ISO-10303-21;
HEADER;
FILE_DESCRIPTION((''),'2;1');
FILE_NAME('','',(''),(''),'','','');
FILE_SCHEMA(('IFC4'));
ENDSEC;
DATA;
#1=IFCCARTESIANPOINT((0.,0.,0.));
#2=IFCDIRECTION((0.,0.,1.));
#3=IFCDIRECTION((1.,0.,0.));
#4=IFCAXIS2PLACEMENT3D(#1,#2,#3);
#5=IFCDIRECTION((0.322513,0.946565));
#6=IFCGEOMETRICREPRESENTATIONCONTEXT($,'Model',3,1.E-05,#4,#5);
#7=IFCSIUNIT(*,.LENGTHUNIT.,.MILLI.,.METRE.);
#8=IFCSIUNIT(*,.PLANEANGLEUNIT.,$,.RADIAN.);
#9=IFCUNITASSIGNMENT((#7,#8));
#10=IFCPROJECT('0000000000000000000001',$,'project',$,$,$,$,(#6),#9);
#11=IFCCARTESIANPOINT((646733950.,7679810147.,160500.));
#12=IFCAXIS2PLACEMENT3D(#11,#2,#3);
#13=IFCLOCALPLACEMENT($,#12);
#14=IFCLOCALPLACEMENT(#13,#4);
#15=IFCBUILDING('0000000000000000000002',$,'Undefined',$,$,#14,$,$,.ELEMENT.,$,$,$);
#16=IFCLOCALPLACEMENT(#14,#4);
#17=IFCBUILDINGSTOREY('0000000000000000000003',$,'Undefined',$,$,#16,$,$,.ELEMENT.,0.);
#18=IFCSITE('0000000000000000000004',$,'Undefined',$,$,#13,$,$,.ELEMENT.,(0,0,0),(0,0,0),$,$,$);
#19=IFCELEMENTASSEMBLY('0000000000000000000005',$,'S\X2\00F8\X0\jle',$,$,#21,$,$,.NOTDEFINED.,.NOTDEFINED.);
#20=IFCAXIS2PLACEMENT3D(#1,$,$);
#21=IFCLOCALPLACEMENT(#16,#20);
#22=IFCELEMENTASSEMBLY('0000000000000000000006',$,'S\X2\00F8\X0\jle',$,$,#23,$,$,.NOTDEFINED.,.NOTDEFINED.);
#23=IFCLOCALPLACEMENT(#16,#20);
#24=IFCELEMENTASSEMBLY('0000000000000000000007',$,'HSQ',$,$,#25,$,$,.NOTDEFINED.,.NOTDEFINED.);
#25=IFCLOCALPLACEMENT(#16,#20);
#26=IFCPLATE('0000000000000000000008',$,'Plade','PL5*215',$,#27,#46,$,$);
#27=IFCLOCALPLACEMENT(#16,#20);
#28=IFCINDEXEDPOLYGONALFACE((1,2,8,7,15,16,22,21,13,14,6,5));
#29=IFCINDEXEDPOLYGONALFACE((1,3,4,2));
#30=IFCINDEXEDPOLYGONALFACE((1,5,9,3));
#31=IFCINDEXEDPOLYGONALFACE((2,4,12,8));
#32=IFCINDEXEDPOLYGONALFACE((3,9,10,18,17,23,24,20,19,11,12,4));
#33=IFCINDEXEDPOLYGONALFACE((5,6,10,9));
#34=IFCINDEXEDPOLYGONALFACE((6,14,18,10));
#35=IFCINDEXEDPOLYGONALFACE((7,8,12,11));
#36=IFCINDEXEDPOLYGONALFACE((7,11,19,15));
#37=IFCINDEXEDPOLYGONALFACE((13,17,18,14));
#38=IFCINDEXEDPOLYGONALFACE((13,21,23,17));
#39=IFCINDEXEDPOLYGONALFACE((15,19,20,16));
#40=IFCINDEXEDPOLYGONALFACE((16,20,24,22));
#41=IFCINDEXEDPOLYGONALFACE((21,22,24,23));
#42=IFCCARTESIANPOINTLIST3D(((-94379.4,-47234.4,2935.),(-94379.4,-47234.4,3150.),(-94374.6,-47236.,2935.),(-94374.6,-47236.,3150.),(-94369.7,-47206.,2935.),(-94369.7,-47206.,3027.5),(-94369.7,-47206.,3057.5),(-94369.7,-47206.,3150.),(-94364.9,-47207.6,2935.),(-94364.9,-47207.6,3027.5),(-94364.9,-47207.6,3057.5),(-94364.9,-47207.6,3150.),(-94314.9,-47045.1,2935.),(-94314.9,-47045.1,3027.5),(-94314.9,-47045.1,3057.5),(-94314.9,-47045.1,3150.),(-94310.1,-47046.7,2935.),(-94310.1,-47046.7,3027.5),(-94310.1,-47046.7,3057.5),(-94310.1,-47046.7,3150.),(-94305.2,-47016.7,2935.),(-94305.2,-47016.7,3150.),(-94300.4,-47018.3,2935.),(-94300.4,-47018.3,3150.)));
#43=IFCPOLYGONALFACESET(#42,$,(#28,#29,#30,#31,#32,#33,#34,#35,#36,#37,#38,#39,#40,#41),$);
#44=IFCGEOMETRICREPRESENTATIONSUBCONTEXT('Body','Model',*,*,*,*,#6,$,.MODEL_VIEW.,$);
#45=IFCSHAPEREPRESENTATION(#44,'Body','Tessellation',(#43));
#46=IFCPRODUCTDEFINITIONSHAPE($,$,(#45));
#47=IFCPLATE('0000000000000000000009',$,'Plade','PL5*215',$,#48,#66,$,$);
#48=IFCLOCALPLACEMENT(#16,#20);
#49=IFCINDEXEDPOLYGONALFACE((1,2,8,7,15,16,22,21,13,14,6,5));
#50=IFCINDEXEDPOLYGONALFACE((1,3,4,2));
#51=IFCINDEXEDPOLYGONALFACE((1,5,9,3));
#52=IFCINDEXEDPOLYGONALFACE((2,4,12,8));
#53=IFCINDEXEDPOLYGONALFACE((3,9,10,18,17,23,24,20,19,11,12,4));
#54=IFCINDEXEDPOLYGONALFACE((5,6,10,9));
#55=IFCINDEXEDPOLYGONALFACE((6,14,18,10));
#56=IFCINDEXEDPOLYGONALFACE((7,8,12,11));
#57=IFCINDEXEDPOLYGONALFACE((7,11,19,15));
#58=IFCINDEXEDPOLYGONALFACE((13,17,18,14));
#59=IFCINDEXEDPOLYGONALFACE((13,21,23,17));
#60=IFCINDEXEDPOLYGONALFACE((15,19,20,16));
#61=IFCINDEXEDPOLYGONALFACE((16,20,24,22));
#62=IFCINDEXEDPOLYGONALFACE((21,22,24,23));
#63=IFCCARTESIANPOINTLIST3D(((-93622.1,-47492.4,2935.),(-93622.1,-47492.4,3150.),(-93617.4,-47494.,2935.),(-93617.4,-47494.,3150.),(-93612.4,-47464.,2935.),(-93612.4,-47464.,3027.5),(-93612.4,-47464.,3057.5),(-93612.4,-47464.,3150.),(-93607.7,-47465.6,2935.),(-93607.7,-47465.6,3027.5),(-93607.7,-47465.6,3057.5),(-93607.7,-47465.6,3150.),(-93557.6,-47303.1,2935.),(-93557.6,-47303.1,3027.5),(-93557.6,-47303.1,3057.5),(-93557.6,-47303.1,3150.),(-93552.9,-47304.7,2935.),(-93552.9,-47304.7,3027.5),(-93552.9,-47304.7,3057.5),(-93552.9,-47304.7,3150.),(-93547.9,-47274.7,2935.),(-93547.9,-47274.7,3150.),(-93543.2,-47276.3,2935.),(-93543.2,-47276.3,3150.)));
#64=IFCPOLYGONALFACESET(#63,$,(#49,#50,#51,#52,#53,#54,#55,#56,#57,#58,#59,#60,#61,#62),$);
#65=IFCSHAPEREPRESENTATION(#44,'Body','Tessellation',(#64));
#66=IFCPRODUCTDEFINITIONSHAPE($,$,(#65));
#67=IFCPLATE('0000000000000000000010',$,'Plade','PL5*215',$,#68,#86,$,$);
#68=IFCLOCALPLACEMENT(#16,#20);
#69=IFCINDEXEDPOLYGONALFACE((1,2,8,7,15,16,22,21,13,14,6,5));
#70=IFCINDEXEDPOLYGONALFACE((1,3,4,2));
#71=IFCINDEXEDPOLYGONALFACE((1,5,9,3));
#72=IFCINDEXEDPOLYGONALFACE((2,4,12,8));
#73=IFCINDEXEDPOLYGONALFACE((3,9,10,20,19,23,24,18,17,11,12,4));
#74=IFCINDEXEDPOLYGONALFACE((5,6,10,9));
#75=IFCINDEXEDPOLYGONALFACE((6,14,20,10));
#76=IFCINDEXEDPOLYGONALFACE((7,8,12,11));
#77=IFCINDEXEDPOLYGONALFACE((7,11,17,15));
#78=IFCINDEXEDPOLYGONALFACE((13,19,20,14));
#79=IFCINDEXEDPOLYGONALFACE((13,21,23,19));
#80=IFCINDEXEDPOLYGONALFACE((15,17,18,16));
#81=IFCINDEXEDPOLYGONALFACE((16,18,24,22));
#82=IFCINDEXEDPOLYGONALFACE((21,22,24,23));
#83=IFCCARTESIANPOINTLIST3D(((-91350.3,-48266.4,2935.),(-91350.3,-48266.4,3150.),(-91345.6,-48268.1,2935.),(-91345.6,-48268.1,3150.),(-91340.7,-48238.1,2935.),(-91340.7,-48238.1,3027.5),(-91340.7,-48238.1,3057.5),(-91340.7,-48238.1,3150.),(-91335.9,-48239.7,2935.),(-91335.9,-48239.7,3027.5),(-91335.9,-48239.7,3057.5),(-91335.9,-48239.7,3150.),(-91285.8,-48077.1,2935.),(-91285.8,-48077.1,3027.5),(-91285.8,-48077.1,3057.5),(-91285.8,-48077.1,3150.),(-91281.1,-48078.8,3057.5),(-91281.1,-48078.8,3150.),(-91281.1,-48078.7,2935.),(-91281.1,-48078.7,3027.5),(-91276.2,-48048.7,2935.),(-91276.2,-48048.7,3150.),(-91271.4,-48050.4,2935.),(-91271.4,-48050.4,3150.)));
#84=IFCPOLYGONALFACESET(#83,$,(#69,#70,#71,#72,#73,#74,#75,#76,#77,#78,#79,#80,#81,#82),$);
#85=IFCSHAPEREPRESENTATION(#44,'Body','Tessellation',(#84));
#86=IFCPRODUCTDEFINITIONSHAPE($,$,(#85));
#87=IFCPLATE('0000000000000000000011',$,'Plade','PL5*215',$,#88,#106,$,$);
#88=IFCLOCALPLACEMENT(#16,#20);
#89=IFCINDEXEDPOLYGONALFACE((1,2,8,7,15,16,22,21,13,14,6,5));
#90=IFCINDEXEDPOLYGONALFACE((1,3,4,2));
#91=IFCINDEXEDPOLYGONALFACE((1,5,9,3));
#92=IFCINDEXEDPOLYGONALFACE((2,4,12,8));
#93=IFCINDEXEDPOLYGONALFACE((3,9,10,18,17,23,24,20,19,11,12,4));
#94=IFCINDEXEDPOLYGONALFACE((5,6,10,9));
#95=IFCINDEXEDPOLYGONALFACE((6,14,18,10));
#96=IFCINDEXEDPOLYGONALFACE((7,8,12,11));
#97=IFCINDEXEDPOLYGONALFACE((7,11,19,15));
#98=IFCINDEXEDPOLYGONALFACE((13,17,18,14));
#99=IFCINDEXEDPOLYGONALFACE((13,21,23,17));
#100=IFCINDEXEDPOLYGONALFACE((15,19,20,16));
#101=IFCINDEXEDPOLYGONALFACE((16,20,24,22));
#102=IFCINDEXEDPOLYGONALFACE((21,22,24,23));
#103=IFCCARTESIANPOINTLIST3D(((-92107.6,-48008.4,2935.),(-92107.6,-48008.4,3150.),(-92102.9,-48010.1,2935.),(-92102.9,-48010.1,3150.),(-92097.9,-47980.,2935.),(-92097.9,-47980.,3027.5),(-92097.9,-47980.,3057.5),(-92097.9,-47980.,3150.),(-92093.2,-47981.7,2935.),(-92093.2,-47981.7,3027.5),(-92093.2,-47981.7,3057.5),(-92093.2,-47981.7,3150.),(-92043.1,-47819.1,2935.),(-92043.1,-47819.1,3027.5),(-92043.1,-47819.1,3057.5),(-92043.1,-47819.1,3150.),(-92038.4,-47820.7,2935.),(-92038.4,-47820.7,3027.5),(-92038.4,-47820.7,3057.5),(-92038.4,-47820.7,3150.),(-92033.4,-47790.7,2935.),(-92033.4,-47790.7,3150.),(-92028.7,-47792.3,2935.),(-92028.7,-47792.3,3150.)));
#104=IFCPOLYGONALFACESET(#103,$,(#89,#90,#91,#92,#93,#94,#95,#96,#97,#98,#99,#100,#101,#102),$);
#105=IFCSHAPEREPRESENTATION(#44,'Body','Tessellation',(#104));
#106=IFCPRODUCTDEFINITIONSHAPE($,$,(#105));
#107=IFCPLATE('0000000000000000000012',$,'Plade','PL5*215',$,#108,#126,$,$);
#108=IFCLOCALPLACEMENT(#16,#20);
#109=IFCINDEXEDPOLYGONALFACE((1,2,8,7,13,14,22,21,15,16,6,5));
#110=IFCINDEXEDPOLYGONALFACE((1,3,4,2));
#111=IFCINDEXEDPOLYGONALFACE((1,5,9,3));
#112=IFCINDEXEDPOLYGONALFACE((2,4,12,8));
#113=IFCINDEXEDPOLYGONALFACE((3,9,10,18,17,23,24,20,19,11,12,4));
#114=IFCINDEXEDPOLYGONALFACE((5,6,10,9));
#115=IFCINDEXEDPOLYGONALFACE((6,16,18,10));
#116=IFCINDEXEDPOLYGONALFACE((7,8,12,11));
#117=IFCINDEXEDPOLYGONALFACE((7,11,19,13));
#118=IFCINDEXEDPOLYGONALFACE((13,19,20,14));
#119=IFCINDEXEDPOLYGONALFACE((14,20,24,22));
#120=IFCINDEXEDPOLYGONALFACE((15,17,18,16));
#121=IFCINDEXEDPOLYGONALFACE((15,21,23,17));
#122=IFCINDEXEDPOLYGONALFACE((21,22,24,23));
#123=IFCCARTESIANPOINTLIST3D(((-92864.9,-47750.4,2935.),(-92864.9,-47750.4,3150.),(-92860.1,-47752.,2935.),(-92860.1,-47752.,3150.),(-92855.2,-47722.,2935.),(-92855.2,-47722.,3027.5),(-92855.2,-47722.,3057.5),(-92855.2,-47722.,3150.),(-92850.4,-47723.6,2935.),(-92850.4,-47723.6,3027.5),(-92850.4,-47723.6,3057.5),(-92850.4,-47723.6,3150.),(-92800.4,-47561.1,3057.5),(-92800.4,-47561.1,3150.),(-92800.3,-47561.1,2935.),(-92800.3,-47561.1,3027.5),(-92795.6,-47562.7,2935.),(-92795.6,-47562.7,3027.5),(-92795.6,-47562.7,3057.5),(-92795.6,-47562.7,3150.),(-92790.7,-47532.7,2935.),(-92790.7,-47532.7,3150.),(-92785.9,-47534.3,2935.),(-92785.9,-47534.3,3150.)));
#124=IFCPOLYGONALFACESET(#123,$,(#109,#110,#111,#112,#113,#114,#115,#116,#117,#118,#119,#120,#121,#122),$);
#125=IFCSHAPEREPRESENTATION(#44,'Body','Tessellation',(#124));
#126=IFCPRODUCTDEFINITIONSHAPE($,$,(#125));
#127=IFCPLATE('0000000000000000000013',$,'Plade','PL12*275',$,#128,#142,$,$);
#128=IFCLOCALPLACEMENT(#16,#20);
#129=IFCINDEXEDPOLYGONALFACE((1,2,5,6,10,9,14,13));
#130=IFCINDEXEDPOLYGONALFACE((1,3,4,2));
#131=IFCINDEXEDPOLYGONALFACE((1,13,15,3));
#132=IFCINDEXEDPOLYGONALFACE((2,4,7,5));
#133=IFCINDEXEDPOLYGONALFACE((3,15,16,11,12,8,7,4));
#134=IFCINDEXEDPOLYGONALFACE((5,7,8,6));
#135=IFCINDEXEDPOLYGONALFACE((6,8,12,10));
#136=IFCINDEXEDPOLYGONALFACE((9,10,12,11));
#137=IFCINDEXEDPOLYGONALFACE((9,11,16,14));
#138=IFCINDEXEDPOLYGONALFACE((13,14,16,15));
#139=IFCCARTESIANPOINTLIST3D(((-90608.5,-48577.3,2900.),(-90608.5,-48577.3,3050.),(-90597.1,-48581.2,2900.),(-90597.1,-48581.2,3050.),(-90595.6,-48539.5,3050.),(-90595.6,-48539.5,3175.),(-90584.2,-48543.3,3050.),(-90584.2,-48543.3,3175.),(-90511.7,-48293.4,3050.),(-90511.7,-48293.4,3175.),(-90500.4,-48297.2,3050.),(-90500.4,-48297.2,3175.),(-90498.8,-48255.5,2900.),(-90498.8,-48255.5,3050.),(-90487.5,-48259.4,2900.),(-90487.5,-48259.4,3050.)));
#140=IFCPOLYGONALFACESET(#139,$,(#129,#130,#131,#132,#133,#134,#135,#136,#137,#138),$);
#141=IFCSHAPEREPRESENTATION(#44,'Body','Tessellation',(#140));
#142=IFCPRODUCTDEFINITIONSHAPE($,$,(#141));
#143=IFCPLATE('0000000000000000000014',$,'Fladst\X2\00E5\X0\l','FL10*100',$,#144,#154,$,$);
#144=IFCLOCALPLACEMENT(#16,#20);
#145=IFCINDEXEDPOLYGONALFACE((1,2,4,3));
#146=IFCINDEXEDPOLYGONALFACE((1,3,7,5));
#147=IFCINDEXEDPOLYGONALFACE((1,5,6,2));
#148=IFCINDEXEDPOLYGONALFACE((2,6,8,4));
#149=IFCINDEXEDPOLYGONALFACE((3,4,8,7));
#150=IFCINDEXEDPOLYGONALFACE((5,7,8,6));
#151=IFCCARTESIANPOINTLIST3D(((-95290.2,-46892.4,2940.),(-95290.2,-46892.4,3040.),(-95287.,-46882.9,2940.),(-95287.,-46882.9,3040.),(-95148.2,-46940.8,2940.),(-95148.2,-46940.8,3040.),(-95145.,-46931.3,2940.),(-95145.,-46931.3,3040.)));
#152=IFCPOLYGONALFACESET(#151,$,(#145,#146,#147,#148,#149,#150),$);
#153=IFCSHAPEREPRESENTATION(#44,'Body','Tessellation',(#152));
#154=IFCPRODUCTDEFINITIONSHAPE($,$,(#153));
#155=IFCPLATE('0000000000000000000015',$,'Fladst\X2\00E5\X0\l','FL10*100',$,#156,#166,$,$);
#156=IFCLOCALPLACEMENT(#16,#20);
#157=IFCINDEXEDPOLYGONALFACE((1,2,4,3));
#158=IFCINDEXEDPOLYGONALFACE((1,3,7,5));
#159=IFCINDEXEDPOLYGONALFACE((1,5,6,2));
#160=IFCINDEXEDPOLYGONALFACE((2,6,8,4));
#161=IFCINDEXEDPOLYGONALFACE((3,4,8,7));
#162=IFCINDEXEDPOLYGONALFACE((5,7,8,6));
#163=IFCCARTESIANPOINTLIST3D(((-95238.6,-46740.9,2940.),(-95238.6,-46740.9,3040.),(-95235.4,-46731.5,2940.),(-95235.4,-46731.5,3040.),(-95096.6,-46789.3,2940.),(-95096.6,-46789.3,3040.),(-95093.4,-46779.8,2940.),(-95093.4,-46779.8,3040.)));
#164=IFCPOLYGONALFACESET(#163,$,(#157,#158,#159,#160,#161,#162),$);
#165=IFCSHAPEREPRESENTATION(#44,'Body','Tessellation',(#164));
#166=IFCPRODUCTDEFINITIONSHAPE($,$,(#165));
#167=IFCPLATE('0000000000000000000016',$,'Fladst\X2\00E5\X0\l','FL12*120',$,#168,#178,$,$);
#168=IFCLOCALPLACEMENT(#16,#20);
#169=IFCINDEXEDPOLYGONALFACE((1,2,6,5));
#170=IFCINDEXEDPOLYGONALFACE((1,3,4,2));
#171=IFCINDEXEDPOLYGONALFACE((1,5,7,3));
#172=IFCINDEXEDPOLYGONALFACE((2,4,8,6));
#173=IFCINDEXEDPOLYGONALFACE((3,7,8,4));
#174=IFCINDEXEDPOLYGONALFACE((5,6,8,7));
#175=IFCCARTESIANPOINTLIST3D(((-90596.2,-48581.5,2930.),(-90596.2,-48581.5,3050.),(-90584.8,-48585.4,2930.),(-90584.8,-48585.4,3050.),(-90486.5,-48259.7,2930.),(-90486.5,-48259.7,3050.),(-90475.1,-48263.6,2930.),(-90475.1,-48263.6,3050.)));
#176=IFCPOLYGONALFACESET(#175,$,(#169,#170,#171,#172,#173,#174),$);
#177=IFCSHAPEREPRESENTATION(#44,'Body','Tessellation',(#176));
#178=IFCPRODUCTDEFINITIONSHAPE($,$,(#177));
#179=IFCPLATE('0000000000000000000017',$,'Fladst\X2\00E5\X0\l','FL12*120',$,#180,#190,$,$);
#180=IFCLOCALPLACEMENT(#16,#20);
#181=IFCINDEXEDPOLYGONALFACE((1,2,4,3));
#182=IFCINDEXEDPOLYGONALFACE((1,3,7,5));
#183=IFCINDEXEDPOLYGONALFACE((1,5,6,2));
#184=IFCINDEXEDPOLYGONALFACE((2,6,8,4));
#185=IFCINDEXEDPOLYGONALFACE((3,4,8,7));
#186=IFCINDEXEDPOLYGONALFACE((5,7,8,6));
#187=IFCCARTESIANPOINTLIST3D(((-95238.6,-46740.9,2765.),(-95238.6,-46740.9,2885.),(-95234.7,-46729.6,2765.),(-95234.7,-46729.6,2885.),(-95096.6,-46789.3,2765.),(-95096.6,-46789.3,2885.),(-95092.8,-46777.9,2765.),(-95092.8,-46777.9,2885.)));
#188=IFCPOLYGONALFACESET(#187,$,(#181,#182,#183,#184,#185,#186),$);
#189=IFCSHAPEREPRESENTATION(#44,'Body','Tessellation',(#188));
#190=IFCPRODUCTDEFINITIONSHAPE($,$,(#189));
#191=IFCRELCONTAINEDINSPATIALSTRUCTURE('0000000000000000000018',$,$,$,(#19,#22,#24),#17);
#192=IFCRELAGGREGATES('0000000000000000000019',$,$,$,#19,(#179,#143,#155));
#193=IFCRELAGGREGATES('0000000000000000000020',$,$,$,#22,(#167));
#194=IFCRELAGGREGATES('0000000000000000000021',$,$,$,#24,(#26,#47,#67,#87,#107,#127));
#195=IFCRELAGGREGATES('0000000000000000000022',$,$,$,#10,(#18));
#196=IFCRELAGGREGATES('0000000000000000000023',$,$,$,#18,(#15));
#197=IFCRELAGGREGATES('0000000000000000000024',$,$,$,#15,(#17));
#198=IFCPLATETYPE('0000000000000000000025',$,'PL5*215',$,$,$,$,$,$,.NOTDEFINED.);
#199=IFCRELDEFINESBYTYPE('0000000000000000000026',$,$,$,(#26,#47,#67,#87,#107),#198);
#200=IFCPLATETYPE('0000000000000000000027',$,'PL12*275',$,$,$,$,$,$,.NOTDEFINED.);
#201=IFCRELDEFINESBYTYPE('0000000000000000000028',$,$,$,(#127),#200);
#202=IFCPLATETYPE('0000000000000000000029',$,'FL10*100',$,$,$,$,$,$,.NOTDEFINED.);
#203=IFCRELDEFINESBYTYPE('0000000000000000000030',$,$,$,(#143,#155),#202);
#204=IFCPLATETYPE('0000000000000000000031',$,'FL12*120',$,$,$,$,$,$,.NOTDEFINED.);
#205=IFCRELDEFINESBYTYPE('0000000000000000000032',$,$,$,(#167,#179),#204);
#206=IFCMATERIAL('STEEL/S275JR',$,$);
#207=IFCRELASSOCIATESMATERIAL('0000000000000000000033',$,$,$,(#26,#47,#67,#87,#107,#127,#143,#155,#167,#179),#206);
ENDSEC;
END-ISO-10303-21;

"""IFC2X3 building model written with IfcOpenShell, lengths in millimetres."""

from ifc_helpers import new_model, si_unit, direction, frame, origin_with_axes, place, context, subcontext, project, spatial, polyline, outline, extrude, material, type_object, element, aggregate, save


model = new_model("IFC2X3")

# Units and contexts
model_context = context("Model", 3, precision=1e-05, world=origin_with_axes(), true_north=direction((0.322513, 0.946565)))
body_context = subcontext(model_context, "Body", "Model", "MODEL_VIEW")
ifc_project = project(units=[si_unit("LENGTHUNIT", "METRE", prefix="MILLI"), si_unit("PLANEANGLEUNIT", "RADIAN")], contexts=[model_context])

# Site, building, storey
site_placement = place(None, frame((646733950.0, 7679810147.0, 160500.0), z_axis=(0.0, 0.0, 1.0), x_axis=(1.0, 0.0, 0.0)))
site = spatial("IfcSite", under=ifc_project, at=site_placement, Name="Undefined", CompositionType="ELEMENT", RefLatitude=(0, 0, 0), RefLongitude=(0, 0, 0))
building_placement = place(site_placement, origin_with_axes())
building = spatial("IfcBuilding", under=site, at=building_placement, Name="Undefined", CompositionType="ELEMENT")
storey_placement = place(building_placement, origin_with_axes())
storey = spatial("IfcBuildingStorey", under=building, at=storey_placement, Name="Undefined", CompositionType="ELEMENT", Elevation=0.0)

# Element assembly
assembly_1_placement = place(storey_placement, origin_with_axes())
assembly_1 = element("IfcElementAssembly", 1, at=assembly_1_placement, inside=storey, Name="Søjle", AssemblyPlace="NOTDEFINED", PredefinedType="NOTDEFINED")

# Element assembly
assembly_2_placement = place(storey_placement, origin_with_axes())
assembly_2 = element("IfcElementAssembly", 2, at=assembly_2_placement, inside=storey, Name="Søjle", AssemblyPlace="NOTDEFINED", PredefinedType="NOTDEFINED")
ifc_material_1 = material(Name="STEEL/S275JR")

# Element assembly, plates
assembly_3_placement = place(storey_placement, origin_with_axes())
assembly_3 = element("IfcElementAssembly", 3, at=assembly_3_placement, inside=storey, Name="HSQ", AssemblyPlace="NOTDEFINED", PredefinedType="NOTDEFINED")
plate_type_1 = type_object("IfcPlateType", Name="PL5*215", PredefinedType="NOTDEFINED")
plate_1_placement = place(assembly_3_placement, frame((-94377.0, -47235.2, 3150.0), z_axis=(0.946565, -0.322513, 0.0), x_axis=(0.0, 0.0, -1.0)))
plate_1 = element("IfcPlate", 4, at=plate_1_placement, type_object=plate_type_1, material=ifc_material_1, Name="Plade", Description="PL5*215", context=body_context, shape_type="SweptSolid", body=[
    extrude(outline(polyline([(0.0, 0.0), (215.0, 0.0), (215.0, 30.0), (122.5, 30.0), (122.5, 200.0), (215.0, 200.0), (215.0, 230.0), (0.0, 230.0), (0.0, 200.0), (92.5, 200.0), (92.5, 30.0), (0.0, 30.0), (0.0, 0.0)])), frame((0.0, 0.0, -2.5), z_axis=(0.0, 0.0, 1.0), x_axis=(1.0, 0.0, 0.0)), (0.0, 0.0, 1.0), 5.0),
])
plate_2_placement = place(assembly_3_placement, frame((-93619.7, -47493.2, 3150.0), z_axis=(0.946565, -0.322513, 0.0), x_axis=(0.0, 0.0, -1.0)))
plate_2 = element("IfcPlate", 5, at=plate_2_placement, type_object=plate_type_1, material=ifc_material_1, Name="Plade", Description="PL5*215", context=body_context, shape_type="SweptSolid", body=[
    extrude(outline(polyline([(0.0, 0.0), (215.0, 0.0), (215.0, 30.0), (122.5, 30.0), (122.5, 200.0), (215.0, 200.0), (215.0, 230.0), (0.0, 230.0), (0.0, 200.0), (92.5, 200.0), (92.5, 30.0), (0.0, 30.0), (0.0, 0.0)])), frame((0.0, 0.0, -2.5), z_axis=(0.0, 0.0, 1.0), x_axis=(1.0, 0.0, 0.0)), (0.0, 0.0, 1.0), 5.0),
])
plate_3_placement = place(assembly_3_placement, frame((-91348.0, -48267.3, 3150.0), z_axis=(0.946565, -0.322513, 0.0), x_axis=(0.0, 0.0, -1.0)))
plate_3 = element("IfcPlate", 6, at=plate_3_placement, type_object=plate_type_1, material=ifc_material_1, Name="Plade", Description="PL5*215", context=body_context, shape_type="SweptSolid", body=[
    extrude(outline(polyline([(0.0, 0.0), (215.0, 0.0), (215.0, 30.0), (122.5, 30.0), (122.5, 200.0), (215.0, 200.0), (215.0, 230.0), (0.0, 230.0), (0.0, 200.0), (92.5, 200.0), (92.5, 30.0), (0.0, 30.0), (0.0, 0.0)])), frame((0.0, 0.0, -2.5), z_axis=(0.0, 0.0, 1.0), x_axis=(1.0, 0.0, 0.0)), (0.0, 0.0, 1.0), 5.0),
])
plate_4_placement = place(assembly_3_placement, frame((-92105.2, -48009.2, 3150.0), z_axis=(0.946565, -0.322513, 0.0), x_axis=(0.0, 0.0, -1.0)))
plate_4 = element("IfcPlate", 7, at=plate_4_placement, type_object=plate_type_1, material=ifc_material_1, Name="Plade", Description="PL5*215", context=body_context, shape_type="SweptSolid", body=[
    extrude(outline(polyline([(0.0, 0.0), (215.0, 0.0), (215.0, 30.0), (122.5, 30.0), (122.5, 200.0), (215.0, 200.0), (215.0, 230.0), (0.0, 230.0), (0.0, 200.0), (92.5, 200.0), (92.5, 30.0), (0.0, 30.0), (0.0, 0.0)])), frame((0.0, 0.0, -2.5), z_axis=(0.0, 0.0, 1.0), x_axis=(1.0, 0.0, 0.0)), (0.0, 0.0, 1.0), 5.0),
])
plate_5_placement = place(assembly_3_placement, frame((-92862.5, -47751.2, 3150.0), z_axis=(0.946565, -0.322513, 0.0), x_axis=(0.0, 0.0, -1.0)))
plate_5 = element("IfcPlate", 8, at=plate_5_placement, type_object=plate_type_1, material=ifc_material_1, Name="Plade", Description="PL5*215", context=body_context, shape_type="SweptSolid", body=[
    extrude(outline(polyline([(0.0, 0.0), (215.0, 0.0), (215.0, 30.0), (122.5, 30.0), (122.5, 200.0), (215.0, 200.0), (215.0, 230.0), (0.0, 230.0), (0.0, 200.0), (92.5, 200.0), (92.5, 30.0), (0.0, 30.0), (0.0, 0.0)])), frame((0.0, 0.0, -2.5), z_axis=(0.0, 0.0, 1.0), x_axis=(1.0, 0.0, 0.0)), (0.0, 0.0, 1.0), 5.0),
])
plate_type_2 = type_object("IfcPlateType", Name="PL12*275", PredefinedType="NOTDEFINED")
plate_6_placement = place(assembly_3_placement, frame((-90493.1, -48257.4, 3175.0), z_axis=(0.946565, -0.322513, 0.0), x_axis=(-0.322513, -0.946565, 0.0)))
plate_6 = element("IfcPlate", 9, at=plate_6_placement, type_object=plate_type_2, material=ifc_material_1, Name="Plade", Description="PL12*275", context=body_context, shape_type="SweptSolid", body=[
    extrude(outline(polyline([(0.0, 125.0), (40.0, 125.0), (40.0, 0.0), (300.0, 0.0), (300.0, 125.0), (340.0, 125.0), (340.0, 275.0), (0.0, 275.0), (0.0, 125.0)])), frame((0.0, 0.0, -6.0), z_axis=(0.0, 0.0, 1.0), x_axis=(1.0, 0.0, 0.0)), (0.0, 0.0, 1.0), 12.0),
])

# Plates
plate_type_3 = type_object("IfcPlateType", Name="FL10*100", PredefinedType="NOTDEFINED")
plate_7_placement = place(assembly_1_placement, frame((-95146.6, -46936.0, 3040.0), z_axis=(-0.322513, -0.946565, 0.0), x_axis=(-0.946565, 0.322513, 0.0)))
plate_7 = element("IfcPlate", 10, at=plate_7_placement, type_object=plate_type_3, material=ifc_material_1, Name="Fladstål", Description="FL10*100", context=body_context, shape_type="SweptSolid", body=[
    extrude(outline(polyline([(0.0, 0.0), (150.0, 0.0), (150.0, 100.0), (0.0, 100.0), (0.0, 0.0)])), frame((0.0, 0.0, -5.0), z_axis=(0.0, 0.0, 1.0), x_axis=(1.0, 0.0, 0.0)), (0.0, 0.0, 1.0), 10.0),
])
plate_8_placement = place(assembly_1_placement, frame((-95095.0, -46784.6, 3040.0), z_axis=(-0.322513, -0.946565, 0.0), x_axis=(-0.946565, 0.322513, 0.0)))
plate_8 = element("IfcPlate", 11, at=plate_8_placement, type_object=plate_type_3, material=ifc_material_1, Name="Fladstål", Description="FL10*100", context=body_context, shape_type="SweptSolid", body=[
    extrude(outline(polyline([(0.0, 0.0), (150.0, 0.0), (150.0, 100.0), (0.0, 100.0), (0.0, 0.0)])), frame((0.0, 0.0, -5.0), z_axis=(0.0, 0.0, 1.0), x_axis=(1.0, 0.0, 0.0)), (0.0, 0.0, 1.0), 10.0),
])
plate_type_4 = type_object("IfcPlateType", Name="FL12*120", PredefinedType="NOTDEFINED")
plate_9_placement = place(assembly_2_placement, frame((-90480.8, -48261.6, 3050.0), z_axis=(0.946565, -0.322513, 0.0), x_axis=(-0.322513, -0.946565, 0.0)))
plate_9 = element("IfcPlate", 12, at=plate_9_placement, type_object=plate_type_4, material=ifc_material_1, Name="Fladstål", Description="FL12*120", context=body_context, shape_type="SweptSolid", body=[
    extrude(outline(polyline([(0.0, 0.0), (340.0, 0.0), (340.0, 120.0), (0.0, 120.0), (0.0, 0.0)])), frame((0.0, 0.0, -6.0), z_axis=(0.0, 0.0, 1.0), x_axis=(1.0, 0.0, 0.0)), (0.0, 0.0, 1.0), 12.0),
])
plate_10_placement = place(assembly_1_placement, frame((-95094.7, -46783.6, 2885.0), z_axis=(-0.322513, -0.946565, 0.0), x_axis=(-0.946565, 0.322513, 0.0)))
plate_10 = element("IfcPlate", 13, at=plate_10_placement, type_object=plate_type_4, material=ifc_material_1, Name="Fladstål", Description="FL12*120", context=body_context, shape_type="SweptSolid", body=[
    extrude(outline(polyline([(0.0, 0.0), (150.0, 0.0), (150.0, 120.0), (0.0, 120.0), (0.0, 0.0)])), frame((0.0, 0.0, -6.0), z_axis=(0.0, 0.0, 1.0), x_axis=(1.0, 0.0, 0.0)), (0.0, 0.0, 1.0), 12.0),
])
aggregate(assembly_1, [plate_10, plate_7, plate_8])

aggregate(assembly_2, [plate_9])

aggregate(assembly_3, [plate_1, plate_2, plate_3, plate_4, plate_5, plate_6])

save(model, "model.ifc")
